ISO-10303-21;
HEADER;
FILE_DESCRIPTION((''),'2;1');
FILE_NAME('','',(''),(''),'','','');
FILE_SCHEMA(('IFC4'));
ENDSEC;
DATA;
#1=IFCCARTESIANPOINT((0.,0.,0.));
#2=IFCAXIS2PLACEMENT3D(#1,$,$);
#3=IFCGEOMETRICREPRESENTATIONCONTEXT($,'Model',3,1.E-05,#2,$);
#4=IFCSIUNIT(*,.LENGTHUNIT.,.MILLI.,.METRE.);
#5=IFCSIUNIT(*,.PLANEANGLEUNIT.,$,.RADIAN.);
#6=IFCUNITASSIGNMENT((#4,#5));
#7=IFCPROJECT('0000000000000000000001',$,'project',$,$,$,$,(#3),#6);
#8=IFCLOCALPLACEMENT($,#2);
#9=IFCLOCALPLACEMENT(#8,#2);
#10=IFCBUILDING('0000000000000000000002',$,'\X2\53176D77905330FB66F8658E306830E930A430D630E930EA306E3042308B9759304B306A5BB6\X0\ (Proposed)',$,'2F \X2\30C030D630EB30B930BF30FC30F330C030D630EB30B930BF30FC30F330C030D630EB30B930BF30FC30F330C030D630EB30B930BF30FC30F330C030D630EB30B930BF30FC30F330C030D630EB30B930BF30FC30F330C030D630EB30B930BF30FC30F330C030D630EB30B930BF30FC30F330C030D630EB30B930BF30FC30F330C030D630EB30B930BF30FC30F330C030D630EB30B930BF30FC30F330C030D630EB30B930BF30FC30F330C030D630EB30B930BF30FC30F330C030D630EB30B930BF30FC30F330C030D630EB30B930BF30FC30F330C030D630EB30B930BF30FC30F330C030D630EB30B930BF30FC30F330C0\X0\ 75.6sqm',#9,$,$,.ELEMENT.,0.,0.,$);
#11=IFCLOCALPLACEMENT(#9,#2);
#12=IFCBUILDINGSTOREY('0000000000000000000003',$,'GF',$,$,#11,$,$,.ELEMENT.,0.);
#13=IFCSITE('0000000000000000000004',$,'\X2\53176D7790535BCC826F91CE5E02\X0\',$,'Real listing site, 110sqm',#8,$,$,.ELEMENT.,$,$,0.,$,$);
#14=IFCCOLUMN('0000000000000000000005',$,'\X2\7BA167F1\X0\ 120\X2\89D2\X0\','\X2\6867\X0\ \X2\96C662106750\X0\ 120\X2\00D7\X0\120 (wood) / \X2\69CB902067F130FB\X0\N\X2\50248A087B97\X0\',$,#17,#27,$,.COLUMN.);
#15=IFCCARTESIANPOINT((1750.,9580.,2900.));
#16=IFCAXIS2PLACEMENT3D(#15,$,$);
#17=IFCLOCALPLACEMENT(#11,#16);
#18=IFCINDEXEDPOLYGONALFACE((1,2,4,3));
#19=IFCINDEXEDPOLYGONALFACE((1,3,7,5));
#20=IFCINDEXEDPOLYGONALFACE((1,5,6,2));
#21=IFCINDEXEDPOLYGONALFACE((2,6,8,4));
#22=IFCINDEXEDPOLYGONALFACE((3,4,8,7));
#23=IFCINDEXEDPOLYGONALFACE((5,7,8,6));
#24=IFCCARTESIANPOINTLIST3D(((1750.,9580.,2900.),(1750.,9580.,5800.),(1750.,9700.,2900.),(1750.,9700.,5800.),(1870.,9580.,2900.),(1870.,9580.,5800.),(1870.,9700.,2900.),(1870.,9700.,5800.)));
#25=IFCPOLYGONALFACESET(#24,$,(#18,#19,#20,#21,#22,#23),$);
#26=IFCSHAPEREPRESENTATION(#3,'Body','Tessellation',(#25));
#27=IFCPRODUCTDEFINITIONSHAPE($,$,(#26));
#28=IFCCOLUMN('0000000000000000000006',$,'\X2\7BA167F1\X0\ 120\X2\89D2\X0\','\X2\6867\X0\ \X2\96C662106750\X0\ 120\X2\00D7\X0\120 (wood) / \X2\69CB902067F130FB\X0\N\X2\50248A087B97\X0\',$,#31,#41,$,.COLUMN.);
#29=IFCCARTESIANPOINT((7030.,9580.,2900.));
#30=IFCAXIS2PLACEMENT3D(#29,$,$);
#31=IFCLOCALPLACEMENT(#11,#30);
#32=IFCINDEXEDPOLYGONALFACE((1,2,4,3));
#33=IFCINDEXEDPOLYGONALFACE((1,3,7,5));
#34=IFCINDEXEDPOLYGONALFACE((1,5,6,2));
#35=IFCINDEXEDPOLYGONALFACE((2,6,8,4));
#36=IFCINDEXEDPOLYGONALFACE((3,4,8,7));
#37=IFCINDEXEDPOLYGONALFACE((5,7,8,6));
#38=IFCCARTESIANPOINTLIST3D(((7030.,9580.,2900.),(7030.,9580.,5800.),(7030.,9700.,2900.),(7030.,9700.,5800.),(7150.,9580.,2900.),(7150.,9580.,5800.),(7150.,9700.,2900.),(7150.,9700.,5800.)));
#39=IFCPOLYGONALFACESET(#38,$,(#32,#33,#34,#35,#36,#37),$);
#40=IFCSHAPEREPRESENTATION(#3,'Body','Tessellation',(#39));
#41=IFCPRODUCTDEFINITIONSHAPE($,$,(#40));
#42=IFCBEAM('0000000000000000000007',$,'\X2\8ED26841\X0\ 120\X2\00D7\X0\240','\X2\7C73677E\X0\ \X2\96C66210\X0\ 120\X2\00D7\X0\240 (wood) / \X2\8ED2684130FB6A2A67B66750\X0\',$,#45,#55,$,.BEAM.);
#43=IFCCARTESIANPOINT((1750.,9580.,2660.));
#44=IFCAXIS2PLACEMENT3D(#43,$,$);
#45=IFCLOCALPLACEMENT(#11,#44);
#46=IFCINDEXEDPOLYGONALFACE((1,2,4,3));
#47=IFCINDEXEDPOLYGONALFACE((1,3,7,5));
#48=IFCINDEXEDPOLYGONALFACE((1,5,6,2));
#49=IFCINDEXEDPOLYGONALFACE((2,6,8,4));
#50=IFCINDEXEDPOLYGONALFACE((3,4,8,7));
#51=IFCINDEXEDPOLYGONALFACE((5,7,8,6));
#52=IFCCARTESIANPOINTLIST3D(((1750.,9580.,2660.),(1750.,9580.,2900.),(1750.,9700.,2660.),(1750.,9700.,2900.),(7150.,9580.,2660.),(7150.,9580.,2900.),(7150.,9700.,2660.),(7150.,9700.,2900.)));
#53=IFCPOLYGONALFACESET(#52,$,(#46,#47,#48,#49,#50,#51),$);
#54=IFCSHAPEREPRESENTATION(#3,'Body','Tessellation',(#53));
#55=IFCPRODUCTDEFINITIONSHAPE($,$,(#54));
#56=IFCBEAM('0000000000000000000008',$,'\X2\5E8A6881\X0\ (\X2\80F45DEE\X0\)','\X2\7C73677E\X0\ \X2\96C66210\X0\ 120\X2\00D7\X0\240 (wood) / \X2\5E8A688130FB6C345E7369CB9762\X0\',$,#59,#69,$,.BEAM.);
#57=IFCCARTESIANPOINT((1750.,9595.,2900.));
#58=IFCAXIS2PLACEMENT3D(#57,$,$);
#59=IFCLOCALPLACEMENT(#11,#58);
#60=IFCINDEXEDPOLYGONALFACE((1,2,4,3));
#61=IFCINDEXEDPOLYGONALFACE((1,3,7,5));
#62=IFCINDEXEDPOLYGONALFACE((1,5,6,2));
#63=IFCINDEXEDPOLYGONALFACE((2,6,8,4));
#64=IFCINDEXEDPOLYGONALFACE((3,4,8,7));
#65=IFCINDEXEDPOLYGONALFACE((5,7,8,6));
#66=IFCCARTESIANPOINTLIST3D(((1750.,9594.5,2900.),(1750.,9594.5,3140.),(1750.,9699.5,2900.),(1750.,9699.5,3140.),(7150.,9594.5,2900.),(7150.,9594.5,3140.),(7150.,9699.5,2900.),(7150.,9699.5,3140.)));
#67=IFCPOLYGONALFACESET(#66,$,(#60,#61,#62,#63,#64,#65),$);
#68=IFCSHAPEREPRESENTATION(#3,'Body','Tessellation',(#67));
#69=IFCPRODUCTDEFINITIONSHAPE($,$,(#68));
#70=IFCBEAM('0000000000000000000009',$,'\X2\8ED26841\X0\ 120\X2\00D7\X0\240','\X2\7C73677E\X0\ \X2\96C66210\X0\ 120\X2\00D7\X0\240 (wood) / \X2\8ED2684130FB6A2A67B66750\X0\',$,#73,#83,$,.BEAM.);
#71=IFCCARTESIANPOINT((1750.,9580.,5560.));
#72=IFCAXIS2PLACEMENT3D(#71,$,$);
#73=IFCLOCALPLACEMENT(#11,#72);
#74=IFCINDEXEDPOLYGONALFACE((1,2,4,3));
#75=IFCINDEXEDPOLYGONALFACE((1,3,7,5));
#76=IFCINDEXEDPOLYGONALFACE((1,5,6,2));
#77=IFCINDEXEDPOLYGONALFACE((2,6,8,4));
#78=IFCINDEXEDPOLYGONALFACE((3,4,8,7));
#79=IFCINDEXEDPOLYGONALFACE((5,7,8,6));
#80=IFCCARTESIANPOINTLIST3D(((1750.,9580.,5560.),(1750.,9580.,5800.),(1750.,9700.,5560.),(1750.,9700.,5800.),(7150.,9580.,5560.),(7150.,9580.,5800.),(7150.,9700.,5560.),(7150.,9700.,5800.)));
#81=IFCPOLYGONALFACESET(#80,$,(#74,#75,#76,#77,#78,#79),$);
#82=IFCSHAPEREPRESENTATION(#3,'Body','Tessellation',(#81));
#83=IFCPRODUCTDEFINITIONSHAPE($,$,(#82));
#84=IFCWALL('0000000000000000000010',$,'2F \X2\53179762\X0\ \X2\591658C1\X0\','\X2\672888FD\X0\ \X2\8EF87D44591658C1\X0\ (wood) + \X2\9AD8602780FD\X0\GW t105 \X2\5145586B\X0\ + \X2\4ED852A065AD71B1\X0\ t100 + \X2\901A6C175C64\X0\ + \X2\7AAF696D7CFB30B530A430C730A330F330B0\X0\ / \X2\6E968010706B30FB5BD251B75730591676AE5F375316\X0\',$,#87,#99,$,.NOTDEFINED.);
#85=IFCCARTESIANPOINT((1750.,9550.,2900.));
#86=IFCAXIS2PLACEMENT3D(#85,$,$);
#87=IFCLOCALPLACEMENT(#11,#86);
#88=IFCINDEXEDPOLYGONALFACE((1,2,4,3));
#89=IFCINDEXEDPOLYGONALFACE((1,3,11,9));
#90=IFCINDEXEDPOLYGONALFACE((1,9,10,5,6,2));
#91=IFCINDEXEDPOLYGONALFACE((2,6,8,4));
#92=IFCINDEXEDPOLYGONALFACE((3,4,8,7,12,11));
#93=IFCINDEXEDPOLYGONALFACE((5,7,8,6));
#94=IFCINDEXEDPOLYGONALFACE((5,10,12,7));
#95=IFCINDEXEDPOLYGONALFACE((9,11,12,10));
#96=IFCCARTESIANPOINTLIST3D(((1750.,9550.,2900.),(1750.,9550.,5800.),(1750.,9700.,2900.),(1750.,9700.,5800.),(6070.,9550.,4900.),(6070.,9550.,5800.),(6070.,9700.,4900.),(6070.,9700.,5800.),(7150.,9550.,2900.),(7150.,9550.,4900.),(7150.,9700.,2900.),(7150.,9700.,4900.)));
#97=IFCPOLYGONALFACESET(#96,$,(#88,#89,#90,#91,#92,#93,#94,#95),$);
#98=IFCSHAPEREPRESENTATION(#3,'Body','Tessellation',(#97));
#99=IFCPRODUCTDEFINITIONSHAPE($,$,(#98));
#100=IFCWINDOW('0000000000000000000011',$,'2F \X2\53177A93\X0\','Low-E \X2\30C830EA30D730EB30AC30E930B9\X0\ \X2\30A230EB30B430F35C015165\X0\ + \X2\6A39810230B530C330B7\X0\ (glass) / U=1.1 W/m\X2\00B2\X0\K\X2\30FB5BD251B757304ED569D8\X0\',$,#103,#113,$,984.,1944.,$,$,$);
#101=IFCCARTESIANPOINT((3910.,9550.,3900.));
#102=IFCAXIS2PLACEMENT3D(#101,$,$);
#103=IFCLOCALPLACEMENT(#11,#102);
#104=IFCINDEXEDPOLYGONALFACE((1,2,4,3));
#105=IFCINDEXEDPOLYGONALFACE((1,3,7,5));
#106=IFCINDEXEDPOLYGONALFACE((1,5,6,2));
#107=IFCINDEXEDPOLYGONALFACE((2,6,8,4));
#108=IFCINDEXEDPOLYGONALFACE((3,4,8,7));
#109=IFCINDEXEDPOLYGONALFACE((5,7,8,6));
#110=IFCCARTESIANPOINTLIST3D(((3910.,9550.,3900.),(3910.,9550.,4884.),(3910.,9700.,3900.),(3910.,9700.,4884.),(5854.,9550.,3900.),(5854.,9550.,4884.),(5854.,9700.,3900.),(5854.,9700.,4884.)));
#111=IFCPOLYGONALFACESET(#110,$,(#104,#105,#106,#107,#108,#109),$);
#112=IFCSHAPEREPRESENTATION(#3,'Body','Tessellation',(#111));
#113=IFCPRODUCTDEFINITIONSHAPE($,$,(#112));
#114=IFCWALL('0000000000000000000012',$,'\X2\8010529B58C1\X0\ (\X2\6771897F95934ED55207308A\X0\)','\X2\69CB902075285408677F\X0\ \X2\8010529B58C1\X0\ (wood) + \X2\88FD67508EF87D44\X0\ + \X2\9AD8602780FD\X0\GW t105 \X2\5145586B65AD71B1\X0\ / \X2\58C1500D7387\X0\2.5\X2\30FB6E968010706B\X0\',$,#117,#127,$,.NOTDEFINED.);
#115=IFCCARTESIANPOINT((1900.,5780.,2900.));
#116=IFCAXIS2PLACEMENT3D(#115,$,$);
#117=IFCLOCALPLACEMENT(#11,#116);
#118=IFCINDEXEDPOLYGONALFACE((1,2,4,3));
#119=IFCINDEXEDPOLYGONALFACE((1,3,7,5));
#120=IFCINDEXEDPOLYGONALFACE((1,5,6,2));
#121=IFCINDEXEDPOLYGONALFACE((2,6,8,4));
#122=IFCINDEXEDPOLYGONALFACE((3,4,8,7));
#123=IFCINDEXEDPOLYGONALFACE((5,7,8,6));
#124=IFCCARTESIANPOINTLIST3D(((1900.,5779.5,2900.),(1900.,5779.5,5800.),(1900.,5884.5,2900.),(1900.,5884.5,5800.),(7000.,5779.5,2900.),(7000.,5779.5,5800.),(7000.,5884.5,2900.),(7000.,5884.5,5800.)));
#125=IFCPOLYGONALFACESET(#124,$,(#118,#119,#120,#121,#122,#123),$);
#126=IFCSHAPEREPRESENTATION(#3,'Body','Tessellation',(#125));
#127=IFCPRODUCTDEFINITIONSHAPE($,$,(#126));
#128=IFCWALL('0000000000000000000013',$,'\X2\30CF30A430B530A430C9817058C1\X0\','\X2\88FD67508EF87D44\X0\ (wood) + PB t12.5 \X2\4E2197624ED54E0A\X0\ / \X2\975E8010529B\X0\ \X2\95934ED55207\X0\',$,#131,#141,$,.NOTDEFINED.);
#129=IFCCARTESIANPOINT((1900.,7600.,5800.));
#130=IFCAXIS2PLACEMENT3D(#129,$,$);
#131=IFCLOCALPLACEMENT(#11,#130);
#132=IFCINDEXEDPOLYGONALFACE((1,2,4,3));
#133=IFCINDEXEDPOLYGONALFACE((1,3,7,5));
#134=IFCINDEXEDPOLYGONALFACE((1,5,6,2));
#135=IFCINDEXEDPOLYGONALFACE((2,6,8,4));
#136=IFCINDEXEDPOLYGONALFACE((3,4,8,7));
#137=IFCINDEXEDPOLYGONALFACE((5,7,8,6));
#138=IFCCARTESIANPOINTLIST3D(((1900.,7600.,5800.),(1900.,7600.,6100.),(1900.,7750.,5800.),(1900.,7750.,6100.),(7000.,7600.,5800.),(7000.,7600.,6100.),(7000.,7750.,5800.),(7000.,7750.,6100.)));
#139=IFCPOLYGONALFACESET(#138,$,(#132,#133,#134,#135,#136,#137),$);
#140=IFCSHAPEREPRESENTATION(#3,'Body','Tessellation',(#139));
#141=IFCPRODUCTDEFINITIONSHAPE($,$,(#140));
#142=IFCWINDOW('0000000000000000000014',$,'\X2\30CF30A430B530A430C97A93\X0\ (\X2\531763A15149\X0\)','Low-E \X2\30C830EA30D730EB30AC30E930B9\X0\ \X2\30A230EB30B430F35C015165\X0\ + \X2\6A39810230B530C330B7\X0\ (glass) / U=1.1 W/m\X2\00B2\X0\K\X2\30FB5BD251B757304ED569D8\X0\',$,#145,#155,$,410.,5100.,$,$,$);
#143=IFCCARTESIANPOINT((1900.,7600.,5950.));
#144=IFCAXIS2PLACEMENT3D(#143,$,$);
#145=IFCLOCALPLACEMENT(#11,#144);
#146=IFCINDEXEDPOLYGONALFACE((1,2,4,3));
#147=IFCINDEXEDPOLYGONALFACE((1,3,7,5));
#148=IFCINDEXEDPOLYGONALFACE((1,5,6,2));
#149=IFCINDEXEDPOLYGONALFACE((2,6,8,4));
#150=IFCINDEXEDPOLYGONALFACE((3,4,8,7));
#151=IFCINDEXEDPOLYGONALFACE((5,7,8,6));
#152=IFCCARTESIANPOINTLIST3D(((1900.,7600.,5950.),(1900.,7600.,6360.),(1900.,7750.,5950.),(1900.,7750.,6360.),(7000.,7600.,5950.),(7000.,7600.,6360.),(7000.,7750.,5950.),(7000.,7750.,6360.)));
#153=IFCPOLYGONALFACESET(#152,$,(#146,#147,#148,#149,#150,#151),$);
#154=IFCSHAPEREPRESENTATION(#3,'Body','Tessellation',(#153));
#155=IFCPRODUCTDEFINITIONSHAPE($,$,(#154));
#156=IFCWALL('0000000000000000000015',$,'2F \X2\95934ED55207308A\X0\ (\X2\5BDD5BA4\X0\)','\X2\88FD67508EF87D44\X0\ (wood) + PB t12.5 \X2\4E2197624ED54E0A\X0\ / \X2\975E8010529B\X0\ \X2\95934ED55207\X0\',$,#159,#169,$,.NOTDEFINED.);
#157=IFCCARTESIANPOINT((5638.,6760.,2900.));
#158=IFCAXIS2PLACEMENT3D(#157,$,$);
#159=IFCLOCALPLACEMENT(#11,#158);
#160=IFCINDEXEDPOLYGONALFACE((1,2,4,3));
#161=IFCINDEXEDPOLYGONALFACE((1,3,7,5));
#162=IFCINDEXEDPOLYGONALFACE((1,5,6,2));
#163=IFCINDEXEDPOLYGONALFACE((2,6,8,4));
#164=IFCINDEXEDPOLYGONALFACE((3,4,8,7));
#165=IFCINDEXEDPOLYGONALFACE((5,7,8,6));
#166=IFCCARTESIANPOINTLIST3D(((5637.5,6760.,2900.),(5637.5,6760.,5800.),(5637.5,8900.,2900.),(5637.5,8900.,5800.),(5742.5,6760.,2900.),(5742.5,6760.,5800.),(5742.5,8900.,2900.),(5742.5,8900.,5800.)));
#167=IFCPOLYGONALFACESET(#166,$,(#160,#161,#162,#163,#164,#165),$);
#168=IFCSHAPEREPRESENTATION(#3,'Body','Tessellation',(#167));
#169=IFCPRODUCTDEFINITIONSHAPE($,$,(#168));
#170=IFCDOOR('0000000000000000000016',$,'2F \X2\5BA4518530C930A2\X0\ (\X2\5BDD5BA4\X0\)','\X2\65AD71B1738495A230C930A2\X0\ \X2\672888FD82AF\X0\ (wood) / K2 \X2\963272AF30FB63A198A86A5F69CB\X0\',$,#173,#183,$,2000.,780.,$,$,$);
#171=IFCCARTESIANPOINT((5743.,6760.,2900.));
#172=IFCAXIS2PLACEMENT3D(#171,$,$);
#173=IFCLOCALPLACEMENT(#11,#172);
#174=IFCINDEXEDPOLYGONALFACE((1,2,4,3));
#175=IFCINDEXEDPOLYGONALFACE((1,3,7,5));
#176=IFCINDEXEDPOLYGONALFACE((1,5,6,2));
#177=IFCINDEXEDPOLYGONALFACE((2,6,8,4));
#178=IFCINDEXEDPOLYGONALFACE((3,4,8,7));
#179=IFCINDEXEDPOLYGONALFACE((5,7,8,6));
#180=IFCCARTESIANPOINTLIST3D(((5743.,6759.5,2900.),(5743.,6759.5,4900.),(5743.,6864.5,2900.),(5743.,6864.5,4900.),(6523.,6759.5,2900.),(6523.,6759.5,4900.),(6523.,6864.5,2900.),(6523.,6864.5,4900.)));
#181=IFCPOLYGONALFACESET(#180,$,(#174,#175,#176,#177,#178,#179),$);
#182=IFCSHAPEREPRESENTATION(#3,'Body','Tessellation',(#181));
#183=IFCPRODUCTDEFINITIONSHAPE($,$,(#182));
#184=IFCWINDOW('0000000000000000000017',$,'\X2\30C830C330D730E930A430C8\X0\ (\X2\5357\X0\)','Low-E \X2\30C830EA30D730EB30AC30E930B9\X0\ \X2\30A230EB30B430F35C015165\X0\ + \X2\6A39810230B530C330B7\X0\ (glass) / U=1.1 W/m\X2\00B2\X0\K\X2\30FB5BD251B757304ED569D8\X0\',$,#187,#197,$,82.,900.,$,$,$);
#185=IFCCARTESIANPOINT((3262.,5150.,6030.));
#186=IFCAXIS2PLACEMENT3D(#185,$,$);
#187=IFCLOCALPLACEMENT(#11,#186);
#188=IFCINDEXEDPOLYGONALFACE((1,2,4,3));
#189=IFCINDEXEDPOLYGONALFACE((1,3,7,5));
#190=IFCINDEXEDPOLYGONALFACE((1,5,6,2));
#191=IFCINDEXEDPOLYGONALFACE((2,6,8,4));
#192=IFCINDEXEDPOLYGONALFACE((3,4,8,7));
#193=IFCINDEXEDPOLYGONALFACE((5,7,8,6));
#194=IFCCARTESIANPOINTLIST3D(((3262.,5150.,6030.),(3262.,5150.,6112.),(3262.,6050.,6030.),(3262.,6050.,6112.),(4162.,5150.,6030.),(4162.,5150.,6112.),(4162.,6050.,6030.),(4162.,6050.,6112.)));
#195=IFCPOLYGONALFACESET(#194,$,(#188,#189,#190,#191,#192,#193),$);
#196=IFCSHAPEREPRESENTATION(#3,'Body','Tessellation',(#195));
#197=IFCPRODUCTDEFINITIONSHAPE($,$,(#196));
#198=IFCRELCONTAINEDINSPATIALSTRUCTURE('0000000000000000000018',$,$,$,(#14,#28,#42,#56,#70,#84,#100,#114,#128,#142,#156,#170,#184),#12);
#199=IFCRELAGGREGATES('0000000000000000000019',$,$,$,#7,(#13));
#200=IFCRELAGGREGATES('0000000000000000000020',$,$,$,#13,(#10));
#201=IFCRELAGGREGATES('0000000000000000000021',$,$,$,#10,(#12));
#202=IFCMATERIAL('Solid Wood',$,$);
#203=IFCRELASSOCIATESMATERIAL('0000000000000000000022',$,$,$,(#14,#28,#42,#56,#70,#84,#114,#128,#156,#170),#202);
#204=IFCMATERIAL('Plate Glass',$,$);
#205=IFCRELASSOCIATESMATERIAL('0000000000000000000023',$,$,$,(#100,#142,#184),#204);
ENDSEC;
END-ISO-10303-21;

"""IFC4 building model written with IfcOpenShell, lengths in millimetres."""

from ifc_helpers import new_model, si_unit, frame, frame_2d, origin, place, context, project, spatial, rectangle, extrude, material, element, fill, save


model = new_model("IFC4")

# Units and contexts
model_context = context("Model", 3, precision=1e-05, world=origin())
ifc_project = project(units=[si_unit("LENGTHUNIT", "METRE", prefix="MILLI"), si_unit("PLANEANGLEUNIT", "RADIAN")], contexts=[model_context])

# Site, building, storey
site_placement = place(None, origin())
site = spatial("IfcSite", under=ifc_project, at=site_placement, Name="北海道富良野市", ObjectType="Real listing site, 110sqm", CompositionType="ELEMENT", RefElevation=0.0)
building_placement = place(site_placement, origin())
building = spatial("IfcBuilding", under=site, at=building_placement, Name="北海道・書斎とライブラリのある静かな家 (Proposed)", ObjectType="2F ダブルスターンダブルスターンダブルスターンダブルスターンダブルスターンダブルスターンダブルスターンダブルスターンダブルスターンダブルスターンダブルスターンダブルスターンダブルスターンダブルスターンダブルスターンダブルスターンダブルスターンダ 75.6sqm", CompositionType="ELEMENT", ElevationOfRefHeight=0.0, ElevationOfTerrain=0.0)
storey_placement = place(building_placement, origin())
storey = spatial("IfcBuildingStorey", under=building, at=storey_placement, Name="GF", CompositionType="ELEMENT", Elevation=0.0)

# Columns
ifc_material_1 = material(Name="Solid Wood")
column_1_placement = place(storey_placement, frame((1750.0, 9580.0, 2900.0)))
element("IfcColumn", 1, at=column_1_placement, inside=storey, material=ifc_material_1, Name="管柱 120角", Description="桧 集成材 120×120 (wood) / 構造柱・N値計算", PredefinedType="COLUMN", context=model_context, shape_type="SweptSolid", body=[
    extrude(rectangle(XDim=120.0, YDim=120.0, at=frame_2d((60.0, 60.0))), frame((1750.0, 9580.0, 2900.0)), (0.0, 0.0, 1.0), 2900.0),
])
column_2_placement = place(storey_placement, frame((7030.0, 9580.0, 2900.0)))
element("IfcColumn", 2, at=column_2_placement, inside=storey, material=ifc_material_1, Name="管柱 120角", Description="桧 集成材 120×120 (wood) / 構造柱・N値計算", PredefinedType="COLUMN", context=model_context, shape_type="SweptSolid", body=[
    extrude(rectangle(XDim=120.0, YDim=120.0, at=frame_2d((60.0, 60.0))), frame((7030.0, 9580.0, 2900.0)), (0.0, 0.0, 1.0), 2900.0),
])

# Beams
beam_1_placement = place(storey_placement, frame((1750.0, 9580.0, 2660.0)))
element("IfcBeam", 3, at=beam_1_placement, inside=storey, material=ifc_material_1, Name="軒桁 120×240", Description="米松 集成 120×240 (wood) / 軒桁・横架材", PredefinedType="BEAM", context=model_context, shape_type="SweptSolid", body=[
    extrude(rectangle(XDim=5400.0, YDim=120.0, at=frame_2d((2700.0, 60.0))), frame((1750.0, 9580.0, 2660.0)), (0.0, 0.0, 1.0), 240.0),
])
beam_2_placement = place(storey_placement, frame((1750.0, 9595.0, 2900.0)))
element("IfcBeam", 4, at=beam_2_placement, inside=storey, material=ifc_material_1, Name="床梁 (胴差)", Description="米松 集成 120×240 (wood) / 床梁・水平構面", PredefinedType="BEAM", context=model_context, shape_type="SweptSolid", body=[
    extrude(rectangle(XDim=5400.0, YDim=105.0, at=frame_2d((2700.0, 52.0))), frame((1750.0, 9595.0, 2900.0)), (0.0, 0.0, 1.0), 240.0),
])
beam_3_placement = place(storey_placement, frame((1750.0, 9580.0, 5560.0)))
element("IfcBeam", 5, at=beam_3_placement, inside=storey, material=ifc_material_1, Name="軒桁 120×240", Description="米松 集成 120×240 (wood) / 軒桁・横架材", PredefinedType="BEAM", context=model_context, shape_type="SweptSolid", body=[
    extrude(rectangle(XDim=5400.0, YDim=120.0, at=frame_2d((2700.0, 60.0))), frame((1750.0, 9580.0, 5560.0)), (0.0, 0.0, 1.0), 240.0),
])

# Wall, opening, window
wall_1_placement = place(storey_placement, frame((1750.0, 9550.0, 2900.0)))
wall_1 = element("IfcWall", 6, at=wall_1_placement, inside=storey, material=ifc_material_1, Name="2F 北面 外壁", Description="木製 軸組外壁 (wood) + 高性能GW t105 充填 + 付加断熱 t100 + 通気層 + 窯業系サイディング / 準耐火・寒冷地外皮強化", PredefinedType="NOTDEFINED", context=model_context, shape_type="SweptSolid", body=[
    extrude(rectangle(XDim=5400.0, YDim=150.0, at=frame_2d((2700.0, 75.0))), frame((1750.0, 9550.0, 2900.0)), (0.0, 0.0, 1.0), 2900.0),
])
opening_1_placement = place(storey_placement, frame((3910.0, 9550.0, 3900.0)))
opening_1 = element("IfcOpeningElement", 7, at=opening_1_placement, cuts=wall_1, PredefinedType="NOTDEFINED", context=model_context, shape_type="SweptSolid", body=[
    extrude(rectangle(XDim=1944.0, YDim=150.0, at=frame_2d((972.0, 75.0))), frame((3910.0, 9550.0, 3900.0)), (0.0, 0.0, 1.0), 984.0),
])
ifc_material_2 = material(Name="Plate Glass")
window_1_placement = place(storey_placement, frame((3910.0, 9550.0, 3900.0)))
window_1 = element("IfcWindow", 8, at=window_1_placement, inside=storey, material=ifc_material_2, Name="2F 北窓", Description="Low-E トリプルガラス アルゴン封入 + 樹脂サッシ (glass) / U=1.1 W/m²K・寒冷地仕様", OverallHeight=984.0, OverallWidth=1944.0, context=model_context, shape_type="SweptSolid", body=[
    extrude(rectangle(XDim=1944.0, YDim=150.0, at=frame_2d((972.0, 75.0))), frame((3910.0, 9550.0, 3900.0)), (0.0, 0.0, 1.0), 984.0),
])
fill(opening_1, window_1)

# Wall
wall_2_placement = place(storey_placement, frame((1900.0, 5780.0, 2900.0)))
element("IfcWall", 9, at=wall_2_placement, inside=storey, material=ifc_material_1, Name="耐力壁 (東西間仕切り)", Description="構造用合板 耐力壁 (wood) + 製材軸組 + 高性能GW t105 充填断熱 / 壁倍率2.5・準耐火", PredefinedType="NOTDEFINED", context=model_context, shape_type="SweptSolid", body=[
    extrude(rectangle(XDim=5100.0, YDim=105.0, at=frame_2d((2550.0, 52.0))), frame((1900.0, 5780.0, 2900.0)), (0.0, 0.0, 1.0), 2900.0),
])

# Wall, opening, window
wall_3_placement = place(storey_placement, frame((1900.0, 7600.0, 5800.0)))
wall_3 = element("IfcWall", 10, at=wall_3_placement, inside=storey, material=ifc_material_1, Name="ハイサイド腰壁", Description="製材軸組 (wood) + PB t12.5 両面仕上 / 非耐力 間仕切", PredefinedType="NOTDEFINED", context=model_context, shape_type="SweptSolid", body=[
    extrude(rectangle(XDim=5100.0, YDim=150.0, at=frame_2d((2550.0, 75.0))), frame((1900.0, 7600.0, 5800.0)), (0.0, 0.0, 1.0), 700.0),
])
opening_2_placement = place(storey_placement, frame((1900.0, 7600.0, 5950.0)))
opening_2 = element("IfcOpeningElement", 11, at=opening_2_placement, cuts=wall_3, PredefinedType="NOTDEFINED", context=model_context, shape_type="SweptSolid", body=[
    extrude(rectangle(XDim=5100.0, YDim=150.0, at=frame_2d((2550.0, 75.0))), frame((1900.0, 7600.0, 5950.0)), (0.0, 0.0, 1.0), 410.0),
])
window_2_placement = place(storey_placement, frame((1900.0, 7600.0, 5950.0)))
window_2 = element("IfcWindow", 12, at=window_2_placement, inside=storey, material=ifc_material_2, Name="ハイサイド窓 (北採光)", Description="Low-E トリプルガラス アルゴン封入 + 樹脂サッシ (glass) / U=1.1 W/m²K・寒冷地仕様", OverallHeight=410.0, OverallWidth=5100.0, context=model_context, shape_type="SweptSolid", body=[
    extrude(rectangle(XDim=5100.0, YDim=150.0, at=frame_2d((2550.0, 75.0))), frame((1900.0, 7600.0, 5950.0)), (0.0, 0.0, 1.0), 410.0),
])
fill(opening_2, window_2)

# Wall
wall_4_placement = place(storey_placement, frame((5638.0, 6760.0, 2900.0)))
element("IfcWall", 13, at=wall_4_placement, inside=storey, material=ifc_material_1, Name="2F 間仕切り (寝室)", Description="製材軸組 (wood) + PB t12.5 両面仕上 / 非耐力 間仕切", PredefinedType="NOTDEFINED", context=model_context, shape_type="SweptSolid", body=[
    extrude(rectangle(XDim=105.0, YDim=2140.0, at=frame_2d((52.0, 1070.0))), frame((5638.0, 6760.0, 2900.0)), (0.0, 0.0, 1.0), 2900.0),
])

# Door
door_placement = place(storey_placement, frame((5743.0, 6760.0, 2900.0)))
element("IfcDoor", 14, at=door_placement, inside=storey, material=ifc_material_1, Name="2F 室内ドア (寝室)", Description="断熱玄関ドア 木製芯 (wood) / K2 防犯・採風機構", OverallHeight=2000.0, OverallWidth=780.0, context=model_context, shape_type="SweptSolid", body=[
    extrude(rectangle(XDim=780.0, YDim=105.0, at=frame_2d((390.0, 52.0))), frame((5743.0, 6760.0, 2900.0)), (0.0, 0.0, 1.0), 2000.0),
])

# Window
window_3_placement = place(storey_placement, frame((3262.0, 5150.0, 6030.0)))
element("IfcWindow", 15, at=window_3_placement, inside=storey, material=ifc_material_2, Name="トップライト (南)", Description="Low-E トリプルガラス アルゴン封入 + 樹脂サッシ (glass) / U=1.1 W/m²K・寒冷地仕様", OverallHeight=82.0, OverallWidth=900.0, context=model_context, shape_type="SweptSolid", body=[
    extrude(rectangle(XDim=900.0, YDim=900.0, at=frame_2d((450.0, 450.0))), frame((3262.0, 5150.0, 6030.0)), (0.0, 0.0, 1.0), 82.0),
])

save(model, "model.ifc")
